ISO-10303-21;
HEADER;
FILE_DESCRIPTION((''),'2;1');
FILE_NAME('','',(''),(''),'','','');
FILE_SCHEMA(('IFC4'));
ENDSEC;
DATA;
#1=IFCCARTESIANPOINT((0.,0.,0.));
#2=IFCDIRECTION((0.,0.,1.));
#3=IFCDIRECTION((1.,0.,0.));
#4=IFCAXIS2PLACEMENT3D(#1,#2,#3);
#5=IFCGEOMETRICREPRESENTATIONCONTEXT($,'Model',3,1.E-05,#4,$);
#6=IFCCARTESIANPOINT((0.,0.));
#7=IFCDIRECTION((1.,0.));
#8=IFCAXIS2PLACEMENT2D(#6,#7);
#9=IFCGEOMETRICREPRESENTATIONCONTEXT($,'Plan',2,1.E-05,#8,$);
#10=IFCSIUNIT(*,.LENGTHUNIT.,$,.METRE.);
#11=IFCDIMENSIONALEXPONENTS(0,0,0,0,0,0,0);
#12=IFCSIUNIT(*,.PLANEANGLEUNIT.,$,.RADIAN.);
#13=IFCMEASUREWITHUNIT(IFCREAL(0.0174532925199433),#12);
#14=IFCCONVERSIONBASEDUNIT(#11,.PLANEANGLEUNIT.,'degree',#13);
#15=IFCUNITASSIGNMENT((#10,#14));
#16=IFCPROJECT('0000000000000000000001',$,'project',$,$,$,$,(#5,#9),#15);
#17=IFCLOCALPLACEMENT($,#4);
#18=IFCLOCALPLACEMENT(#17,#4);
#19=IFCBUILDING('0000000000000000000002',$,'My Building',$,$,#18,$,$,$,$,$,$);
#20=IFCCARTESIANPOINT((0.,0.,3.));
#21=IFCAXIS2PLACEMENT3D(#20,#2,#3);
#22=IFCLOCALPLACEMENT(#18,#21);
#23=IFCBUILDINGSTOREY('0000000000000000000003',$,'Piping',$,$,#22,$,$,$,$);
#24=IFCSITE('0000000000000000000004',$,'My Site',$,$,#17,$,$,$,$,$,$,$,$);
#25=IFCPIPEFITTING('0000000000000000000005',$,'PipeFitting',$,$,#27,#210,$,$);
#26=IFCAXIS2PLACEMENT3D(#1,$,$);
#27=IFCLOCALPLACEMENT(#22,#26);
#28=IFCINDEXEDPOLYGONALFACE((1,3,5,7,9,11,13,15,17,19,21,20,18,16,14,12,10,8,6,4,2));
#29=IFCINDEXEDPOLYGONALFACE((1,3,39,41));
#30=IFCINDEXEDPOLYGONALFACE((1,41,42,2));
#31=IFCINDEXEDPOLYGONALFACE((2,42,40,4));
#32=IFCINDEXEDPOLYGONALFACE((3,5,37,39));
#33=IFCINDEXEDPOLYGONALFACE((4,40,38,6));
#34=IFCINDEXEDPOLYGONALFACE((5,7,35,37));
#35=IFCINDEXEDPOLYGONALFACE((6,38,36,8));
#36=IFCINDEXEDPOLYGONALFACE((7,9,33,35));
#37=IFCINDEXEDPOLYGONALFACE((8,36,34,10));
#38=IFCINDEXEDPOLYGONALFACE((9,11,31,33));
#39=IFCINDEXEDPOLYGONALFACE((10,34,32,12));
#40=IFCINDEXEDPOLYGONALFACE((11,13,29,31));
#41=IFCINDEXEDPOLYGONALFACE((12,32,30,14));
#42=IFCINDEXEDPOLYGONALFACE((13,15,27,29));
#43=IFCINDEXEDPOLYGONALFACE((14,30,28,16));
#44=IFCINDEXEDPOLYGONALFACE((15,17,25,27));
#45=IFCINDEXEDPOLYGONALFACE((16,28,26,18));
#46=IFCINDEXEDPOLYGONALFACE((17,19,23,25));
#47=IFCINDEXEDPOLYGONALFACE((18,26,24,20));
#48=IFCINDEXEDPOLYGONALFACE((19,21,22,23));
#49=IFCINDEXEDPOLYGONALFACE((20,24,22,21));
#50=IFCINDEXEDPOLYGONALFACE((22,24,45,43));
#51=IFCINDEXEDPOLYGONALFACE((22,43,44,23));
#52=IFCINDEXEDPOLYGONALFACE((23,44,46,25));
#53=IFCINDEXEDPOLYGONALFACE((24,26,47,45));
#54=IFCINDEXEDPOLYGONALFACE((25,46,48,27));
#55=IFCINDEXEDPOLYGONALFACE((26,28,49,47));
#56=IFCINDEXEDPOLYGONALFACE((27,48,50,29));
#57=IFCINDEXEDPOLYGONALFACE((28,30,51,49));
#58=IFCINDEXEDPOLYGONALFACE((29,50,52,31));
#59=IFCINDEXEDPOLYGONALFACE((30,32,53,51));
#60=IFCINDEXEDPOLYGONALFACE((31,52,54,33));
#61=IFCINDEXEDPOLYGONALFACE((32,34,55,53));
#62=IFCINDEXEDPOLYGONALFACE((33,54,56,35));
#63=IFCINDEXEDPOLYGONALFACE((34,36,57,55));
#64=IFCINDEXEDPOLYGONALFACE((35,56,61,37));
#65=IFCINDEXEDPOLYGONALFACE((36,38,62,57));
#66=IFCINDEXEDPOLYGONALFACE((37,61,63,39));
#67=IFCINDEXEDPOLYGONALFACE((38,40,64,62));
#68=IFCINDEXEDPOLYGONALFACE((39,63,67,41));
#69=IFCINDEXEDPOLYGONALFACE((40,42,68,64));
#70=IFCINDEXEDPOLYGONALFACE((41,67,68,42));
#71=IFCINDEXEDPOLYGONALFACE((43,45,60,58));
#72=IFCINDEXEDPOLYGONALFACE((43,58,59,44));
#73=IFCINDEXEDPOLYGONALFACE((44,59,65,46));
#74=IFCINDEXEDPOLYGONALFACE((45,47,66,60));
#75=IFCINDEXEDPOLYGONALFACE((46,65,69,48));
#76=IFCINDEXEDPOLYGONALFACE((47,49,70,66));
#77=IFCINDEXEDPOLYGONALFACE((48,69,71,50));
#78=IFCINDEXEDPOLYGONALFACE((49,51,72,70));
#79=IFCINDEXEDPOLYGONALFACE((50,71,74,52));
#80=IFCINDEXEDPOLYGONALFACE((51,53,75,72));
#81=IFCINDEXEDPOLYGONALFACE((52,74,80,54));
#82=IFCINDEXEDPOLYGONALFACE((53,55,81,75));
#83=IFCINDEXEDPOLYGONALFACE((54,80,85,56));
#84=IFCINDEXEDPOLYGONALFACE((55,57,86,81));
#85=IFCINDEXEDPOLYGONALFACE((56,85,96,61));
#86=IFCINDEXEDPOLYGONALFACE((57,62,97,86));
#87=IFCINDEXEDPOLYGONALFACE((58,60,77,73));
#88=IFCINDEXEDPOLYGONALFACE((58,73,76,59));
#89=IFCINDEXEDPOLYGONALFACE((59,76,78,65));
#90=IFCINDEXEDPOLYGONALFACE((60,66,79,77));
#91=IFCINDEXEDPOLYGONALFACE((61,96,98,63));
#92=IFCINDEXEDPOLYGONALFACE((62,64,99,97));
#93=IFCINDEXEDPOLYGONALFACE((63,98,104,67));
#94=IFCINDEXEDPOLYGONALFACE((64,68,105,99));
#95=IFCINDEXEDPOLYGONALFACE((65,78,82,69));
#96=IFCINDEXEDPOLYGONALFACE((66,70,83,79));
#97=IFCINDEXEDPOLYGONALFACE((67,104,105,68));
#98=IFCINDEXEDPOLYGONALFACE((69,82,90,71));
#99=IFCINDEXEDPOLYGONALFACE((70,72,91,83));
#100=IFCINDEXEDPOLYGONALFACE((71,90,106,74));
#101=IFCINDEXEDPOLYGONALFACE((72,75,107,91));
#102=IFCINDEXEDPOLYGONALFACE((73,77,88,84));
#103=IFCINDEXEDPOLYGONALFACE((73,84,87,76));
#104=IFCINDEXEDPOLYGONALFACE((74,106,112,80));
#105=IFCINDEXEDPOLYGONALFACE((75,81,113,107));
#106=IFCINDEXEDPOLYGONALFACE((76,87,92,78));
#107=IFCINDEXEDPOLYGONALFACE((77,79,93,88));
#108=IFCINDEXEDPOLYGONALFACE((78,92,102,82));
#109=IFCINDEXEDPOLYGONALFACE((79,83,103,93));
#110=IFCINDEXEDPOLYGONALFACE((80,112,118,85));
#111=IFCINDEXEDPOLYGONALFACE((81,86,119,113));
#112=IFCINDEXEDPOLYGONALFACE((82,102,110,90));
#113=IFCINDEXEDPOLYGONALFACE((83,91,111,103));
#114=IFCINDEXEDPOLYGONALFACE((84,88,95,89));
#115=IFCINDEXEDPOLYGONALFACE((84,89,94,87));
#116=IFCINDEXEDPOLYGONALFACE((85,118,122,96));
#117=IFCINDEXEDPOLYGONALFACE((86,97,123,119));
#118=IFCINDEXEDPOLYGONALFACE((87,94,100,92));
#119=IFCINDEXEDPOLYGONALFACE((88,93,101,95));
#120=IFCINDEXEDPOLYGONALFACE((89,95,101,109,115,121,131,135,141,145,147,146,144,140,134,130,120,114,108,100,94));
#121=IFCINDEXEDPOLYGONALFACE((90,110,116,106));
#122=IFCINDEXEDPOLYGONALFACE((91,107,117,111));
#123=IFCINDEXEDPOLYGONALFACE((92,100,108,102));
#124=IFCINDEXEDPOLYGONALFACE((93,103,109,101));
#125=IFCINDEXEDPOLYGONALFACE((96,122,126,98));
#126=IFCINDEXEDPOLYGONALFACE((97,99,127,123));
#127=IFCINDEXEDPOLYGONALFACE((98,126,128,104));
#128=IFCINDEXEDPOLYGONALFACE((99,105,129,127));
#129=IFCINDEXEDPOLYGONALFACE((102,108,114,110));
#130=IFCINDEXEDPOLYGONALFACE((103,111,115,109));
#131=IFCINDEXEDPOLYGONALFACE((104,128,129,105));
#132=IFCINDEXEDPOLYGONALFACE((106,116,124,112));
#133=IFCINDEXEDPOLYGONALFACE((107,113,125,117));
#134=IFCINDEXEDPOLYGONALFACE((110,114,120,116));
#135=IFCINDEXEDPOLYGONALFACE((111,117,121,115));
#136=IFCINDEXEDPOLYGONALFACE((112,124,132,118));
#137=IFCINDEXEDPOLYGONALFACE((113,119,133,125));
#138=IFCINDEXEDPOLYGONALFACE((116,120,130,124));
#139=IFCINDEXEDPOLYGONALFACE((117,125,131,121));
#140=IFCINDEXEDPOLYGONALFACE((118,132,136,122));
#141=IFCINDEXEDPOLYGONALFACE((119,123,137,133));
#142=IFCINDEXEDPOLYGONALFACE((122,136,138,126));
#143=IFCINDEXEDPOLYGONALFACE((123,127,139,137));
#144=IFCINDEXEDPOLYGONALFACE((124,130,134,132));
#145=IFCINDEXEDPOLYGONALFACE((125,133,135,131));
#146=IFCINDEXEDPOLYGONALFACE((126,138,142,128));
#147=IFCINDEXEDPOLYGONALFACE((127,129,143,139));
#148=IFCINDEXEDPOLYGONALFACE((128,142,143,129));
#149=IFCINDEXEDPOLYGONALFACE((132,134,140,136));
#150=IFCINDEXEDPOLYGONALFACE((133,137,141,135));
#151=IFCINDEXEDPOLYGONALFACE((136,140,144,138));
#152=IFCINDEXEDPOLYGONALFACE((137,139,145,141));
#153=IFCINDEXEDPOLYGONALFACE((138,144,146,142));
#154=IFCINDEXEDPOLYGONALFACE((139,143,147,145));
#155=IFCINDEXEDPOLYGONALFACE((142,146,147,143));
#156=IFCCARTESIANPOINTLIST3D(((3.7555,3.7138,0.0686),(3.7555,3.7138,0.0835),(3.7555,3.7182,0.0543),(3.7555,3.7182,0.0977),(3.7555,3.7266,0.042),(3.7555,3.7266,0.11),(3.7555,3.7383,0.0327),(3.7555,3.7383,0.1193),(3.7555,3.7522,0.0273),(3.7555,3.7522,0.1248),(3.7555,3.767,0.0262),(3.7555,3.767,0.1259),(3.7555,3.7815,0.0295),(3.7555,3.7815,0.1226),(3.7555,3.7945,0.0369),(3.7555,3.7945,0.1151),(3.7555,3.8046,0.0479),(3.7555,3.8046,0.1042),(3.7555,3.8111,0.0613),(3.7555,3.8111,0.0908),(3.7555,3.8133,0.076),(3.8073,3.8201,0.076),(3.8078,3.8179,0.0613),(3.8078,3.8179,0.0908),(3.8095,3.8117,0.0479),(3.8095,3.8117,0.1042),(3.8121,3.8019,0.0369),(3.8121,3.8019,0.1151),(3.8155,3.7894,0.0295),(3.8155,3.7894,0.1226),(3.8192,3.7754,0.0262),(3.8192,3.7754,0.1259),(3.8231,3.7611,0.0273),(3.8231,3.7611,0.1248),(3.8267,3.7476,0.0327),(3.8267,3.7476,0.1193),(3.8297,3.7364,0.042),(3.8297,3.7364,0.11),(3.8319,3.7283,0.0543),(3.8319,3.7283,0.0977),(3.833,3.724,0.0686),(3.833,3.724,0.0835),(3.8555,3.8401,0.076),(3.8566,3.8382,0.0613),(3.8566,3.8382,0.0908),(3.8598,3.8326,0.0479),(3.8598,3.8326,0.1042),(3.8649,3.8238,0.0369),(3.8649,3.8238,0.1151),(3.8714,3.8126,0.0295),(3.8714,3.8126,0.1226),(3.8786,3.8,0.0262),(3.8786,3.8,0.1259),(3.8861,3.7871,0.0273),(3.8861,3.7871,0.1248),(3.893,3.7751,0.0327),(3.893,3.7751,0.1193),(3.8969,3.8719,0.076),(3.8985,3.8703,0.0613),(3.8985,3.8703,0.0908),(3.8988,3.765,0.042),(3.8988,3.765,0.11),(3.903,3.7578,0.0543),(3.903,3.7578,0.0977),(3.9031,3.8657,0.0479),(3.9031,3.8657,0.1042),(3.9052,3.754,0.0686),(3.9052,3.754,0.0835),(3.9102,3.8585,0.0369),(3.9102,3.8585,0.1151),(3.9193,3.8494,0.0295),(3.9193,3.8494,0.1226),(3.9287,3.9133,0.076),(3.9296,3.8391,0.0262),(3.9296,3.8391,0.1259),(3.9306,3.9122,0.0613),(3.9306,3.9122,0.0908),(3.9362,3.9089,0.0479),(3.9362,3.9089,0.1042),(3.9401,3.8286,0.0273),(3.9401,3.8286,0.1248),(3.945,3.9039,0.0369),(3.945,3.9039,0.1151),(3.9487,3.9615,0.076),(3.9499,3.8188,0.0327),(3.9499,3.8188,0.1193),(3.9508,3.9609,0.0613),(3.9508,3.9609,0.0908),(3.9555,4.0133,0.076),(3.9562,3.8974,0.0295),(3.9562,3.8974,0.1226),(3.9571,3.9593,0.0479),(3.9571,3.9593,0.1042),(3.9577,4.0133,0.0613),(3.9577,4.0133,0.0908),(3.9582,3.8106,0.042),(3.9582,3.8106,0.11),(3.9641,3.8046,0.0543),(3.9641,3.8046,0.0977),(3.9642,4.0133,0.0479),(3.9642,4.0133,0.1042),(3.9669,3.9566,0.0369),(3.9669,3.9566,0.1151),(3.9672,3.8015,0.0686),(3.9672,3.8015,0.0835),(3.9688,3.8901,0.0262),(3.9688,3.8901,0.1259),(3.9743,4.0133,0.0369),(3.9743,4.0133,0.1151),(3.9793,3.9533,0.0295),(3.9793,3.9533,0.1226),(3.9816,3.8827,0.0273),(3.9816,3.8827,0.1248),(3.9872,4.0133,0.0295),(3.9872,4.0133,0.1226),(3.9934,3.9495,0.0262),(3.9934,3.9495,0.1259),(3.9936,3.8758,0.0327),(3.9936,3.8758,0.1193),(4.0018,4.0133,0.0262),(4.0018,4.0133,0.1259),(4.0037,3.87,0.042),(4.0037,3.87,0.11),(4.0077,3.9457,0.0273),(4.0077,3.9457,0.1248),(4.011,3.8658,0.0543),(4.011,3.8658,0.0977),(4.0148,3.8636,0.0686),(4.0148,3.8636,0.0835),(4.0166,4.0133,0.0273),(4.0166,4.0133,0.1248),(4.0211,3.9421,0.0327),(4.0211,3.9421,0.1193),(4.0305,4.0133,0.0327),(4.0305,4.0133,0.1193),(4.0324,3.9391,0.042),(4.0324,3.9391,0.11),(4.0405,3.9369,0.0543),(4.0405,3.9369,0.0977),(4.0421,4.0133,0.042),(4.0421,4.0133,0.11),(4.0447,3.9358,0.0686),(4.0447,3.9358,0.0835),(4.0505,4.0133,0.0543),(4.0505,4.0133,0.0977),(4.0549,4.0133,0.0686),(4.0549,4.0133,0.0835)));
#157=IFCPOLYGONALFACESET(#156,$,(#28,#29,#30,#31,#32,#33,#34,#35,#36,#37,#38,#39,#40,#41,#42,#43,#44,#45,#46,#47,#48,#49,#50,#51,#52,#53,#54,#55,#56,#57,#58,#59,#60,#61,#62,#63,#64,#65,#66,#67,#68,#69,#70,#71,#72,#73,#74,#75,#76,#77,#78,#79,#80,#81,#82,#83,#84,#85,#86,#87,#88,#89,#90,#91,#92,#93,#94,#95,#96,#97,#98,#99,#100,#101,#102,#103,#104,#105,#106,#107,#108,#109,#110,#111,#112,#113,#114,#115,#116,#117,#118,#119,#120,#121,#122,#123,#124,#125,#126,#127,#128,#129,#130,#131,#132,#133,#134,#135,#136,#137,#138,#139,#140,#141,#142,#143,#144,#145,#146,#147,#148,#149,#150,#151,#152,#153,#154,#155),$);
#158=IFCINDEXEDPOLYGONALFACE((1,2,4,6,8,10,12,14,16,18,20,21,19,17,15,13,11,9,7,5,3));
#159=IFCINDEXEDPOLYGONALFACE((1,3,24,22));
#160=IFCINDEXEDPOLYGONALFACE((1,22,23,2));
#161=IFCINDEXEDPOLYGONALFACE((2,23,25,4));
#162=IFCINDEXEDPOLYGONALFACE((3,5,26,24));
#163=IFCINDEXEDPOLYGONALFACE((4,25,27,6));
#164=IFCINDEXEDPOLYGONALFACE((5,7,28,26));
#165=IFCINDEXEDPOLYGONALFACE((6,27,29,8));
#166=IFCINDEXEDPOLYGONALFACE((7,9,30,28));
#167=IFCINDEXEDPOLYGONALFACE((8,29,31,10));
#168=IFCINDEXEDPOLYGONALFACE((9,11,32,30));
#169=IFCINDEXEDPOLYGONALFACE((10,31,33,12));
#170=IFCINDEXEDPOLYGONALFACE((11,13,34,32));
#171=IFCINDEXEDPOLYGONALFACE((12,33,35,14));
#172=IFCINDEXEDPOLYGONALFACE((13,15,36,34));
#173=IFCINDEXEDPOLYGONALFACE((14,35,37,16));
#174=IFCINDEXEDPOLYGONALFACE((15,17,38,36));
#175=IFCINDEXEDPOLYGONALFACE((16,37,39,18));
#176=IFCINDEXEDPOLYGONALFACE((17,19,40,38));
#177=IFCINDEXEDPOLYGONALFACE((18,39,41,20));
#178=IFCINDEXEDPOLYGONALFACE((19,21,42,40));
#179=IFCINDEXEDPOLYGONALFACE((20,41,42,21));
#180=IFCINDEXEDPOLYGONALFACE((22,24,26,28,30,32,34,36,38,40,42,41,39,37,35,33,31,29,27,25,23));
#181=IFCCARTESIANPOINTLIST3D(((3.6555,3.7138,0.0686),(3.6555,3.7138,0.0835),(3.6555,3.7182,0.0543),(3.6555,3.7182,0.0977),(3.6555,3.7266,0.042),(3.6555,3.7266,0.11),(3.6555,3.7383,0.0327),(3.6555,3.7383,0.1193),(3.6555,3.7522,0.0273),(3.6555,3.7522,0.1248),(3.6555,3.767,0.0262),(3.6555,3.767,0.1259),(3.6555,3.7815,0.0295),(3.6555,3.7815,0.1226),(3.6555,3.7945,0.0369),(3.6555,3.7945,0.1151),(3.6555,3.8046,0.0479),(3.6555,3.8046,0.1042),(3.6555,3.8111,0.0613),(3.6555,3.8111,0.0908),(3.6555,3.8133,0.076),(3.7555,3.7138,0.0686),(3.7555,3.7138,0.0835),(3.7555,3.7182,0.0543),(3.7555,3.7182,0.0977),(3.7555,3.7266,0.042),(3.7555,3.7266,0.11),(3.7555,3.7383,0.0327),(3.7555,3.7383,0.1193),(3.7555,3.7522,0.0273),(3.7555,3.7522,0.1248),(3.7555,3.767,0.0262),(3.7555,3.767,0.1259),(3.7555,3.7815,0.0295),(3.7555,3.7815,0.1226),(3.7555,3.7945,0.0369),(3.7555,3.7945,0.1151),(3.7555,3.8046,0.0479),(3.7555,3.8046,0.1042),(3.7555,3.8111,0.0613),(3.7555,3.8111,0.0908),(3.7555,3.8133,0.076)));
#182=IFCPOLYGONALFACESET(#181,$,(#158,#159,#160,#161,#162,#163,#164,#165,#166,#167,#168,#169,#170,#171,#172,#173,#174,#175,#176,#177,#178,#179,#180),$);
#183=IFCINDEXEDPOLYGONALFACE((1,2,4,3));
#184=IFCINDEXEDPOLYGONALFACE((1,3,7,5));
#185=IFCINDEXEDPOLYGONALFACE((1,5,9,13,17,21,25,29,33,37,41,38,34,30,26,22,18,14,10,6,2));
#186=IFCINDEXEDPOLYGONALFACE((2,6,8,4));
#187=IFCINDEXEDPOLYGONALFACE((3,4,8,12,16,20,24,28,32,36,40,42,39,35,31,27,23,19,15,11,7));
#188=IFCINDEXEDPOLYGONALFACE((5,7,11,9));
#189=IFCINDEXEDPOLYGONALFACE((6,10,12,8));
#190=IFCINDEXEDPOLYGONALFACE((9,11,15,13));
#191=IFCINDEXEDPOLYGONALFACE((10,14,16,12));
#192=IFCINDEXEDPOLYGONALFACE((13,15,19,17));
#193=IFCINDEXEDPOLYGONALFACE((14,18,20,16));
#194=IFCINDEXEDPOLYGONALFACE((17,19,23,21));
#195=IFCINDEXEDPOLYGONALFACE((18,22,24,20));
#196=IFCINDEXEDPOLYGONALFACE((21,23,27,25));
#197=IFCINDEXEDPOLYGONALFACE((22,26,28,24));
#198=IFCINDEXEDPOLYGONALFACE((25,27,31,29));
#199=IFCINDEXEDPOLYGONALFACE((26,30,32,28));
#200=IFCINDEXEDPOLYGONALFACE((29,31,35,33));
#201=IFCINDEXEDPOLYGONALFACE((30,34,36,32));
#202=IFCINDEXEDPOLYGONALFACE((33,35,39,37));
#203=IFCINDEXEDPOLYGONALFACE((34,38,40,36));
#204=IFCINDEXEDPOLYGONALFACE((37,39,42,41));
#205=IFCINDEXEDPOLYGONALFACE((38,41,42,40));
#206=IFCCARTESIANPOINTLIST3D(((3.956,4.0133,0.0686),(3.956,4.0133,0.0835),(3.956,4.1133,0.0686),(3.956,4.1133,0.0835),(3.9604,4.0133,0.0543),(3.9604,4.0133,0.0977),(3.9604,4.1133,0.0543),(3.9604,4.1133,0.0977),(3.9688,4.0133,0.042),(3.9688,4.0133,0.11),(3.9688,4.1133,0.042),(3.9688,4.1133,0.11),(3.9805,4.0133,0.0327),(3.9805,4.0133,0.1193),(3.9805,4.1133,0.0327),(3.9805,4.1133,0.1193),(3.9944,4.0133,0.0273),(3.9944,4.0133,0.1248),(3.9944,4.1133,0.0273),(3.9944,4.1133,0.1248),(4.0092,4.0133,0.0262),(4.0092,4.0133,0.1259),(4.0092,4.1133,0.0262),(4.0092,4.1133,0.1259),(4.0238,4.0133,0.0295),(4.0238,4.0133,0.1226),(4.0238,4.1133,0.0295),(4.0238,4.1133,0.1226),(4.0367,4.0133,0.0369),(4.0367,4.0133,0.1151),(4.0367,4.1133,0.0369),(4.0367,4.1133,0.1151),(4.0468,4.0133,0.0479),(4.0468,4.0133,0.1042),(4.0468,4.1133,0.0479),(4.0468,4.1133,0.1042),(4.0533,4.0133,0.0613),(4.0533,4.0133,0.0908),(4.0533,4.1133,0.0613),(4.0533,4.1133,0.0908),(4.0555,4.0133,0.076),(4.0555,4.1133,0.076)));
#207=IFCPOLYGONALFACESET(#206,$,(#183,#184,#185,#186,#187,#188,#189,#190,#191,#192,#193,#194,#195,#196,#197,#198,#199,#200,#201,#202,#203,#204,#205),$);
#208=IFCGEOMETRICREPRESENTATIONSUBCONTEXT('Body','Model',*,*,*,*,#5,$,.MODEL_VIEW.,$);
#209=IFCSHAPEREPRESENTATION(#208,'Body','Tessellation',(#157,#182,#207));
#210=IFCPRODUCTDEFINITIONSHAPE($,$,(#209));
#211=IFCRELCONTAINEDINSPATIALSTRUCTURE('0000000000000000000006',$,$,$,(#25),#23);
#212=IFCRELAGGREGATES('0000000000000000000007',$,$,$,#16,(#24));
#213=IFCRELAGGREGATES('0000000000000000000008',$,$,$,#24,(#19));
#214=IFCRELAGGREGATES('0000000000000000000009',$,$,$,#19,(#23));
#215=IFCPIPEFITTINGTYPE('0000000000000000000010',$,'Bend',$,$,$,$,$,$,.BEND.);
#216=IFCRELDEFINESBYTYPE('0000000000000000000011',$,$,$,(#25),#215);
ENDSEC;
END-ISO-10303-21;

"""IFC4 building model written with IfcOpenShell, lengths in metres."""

from ifc_helpers import new_model, entity, si_unit, converted_unit, frame, origin_with_axes, origin_2d_with_axis, place, context, subcontext, project, spatial, circle, extrude, source, transform, mapped, type_object, type_shapes, element, save


model = new_model("IFC4")

# Units and contexts
model_context = context("Model", 3, precision=1e-05, world=origin_with_axes())
plan_context = context("Plan", 2, precision=1e-05, world=origin_2d_with_axis())
body_context = subcontext(model_context, "Body", "Model", "MODEL_VIEW")
ifc_project = project(units=[si_unit("LENGTHUNIT", "METRE"), converted_unit("PLANEANGLEUNIT", "degree", entity("IfcReal", 0.0174532925199433), si_unit("PLANEANGLEUNIT", "RADIAN"), dimensions=[0, 0, 0, 0, 0, 0, 0])], contexts=[model_context, plan_context])

# Site, building, storey
site_placement = place(None, origin_with_axes())
site = spatial("IfcSite", under=ifc_project, at=site_placement, Name="My Site")
building_placement = place(site_placement, origin_with_axes())
building = spatial("IfcBuilding", under=site, at=building_placement, Name="My Building")
storey_placement = place(building_placement, frame((0.0, 0.0, 3.0), z_axis=(0.0, 0.0, 1.0), x_axis=(1.0, 0.0, 0.0)))
storey = spatial("IfcBuildingStorey", under=building, at=storey_placement, Name="Piping")

# Pipe fitting
pipe_fitting_type_1 = type_object("IfcPipeFittingType", Name="Bend", PredefinedType="BEND")
shared_shape_1 = source(origin_with_axes(), body_context, "Body", "SolidModel", [
    entity("IfcSweptDiskSolid", entity("IfcIndexedPolyCurve", entity("IfcCartesianPointList3D", [[0.0, 0.0, 0.1], [0.0732, 0.0, 0.2768], [0.25, 0.0, 0.35]]), [entity("IfcArcIndex", [1, 2, 3])]), 0.05),
    extrude(circle(Radius=0.05), origin_with_axes(), (0.0, 0.0, 1.0), 0.1),
    extrude(circle(Radius=0.05), frame((0.25, 0.0, 0.35), z_axis=(1.0, 0.0, 0.0), x_axis=(0.0, 0.0, 1.0)), (0.0, 0.0, 1.0), 0.1),
])
type_shapes(pipe_fitting_type_1, [shared_shape_1])
for number, where, z_axis, x_axis, name in (
    (1, (3.6555, 3.7633, 0.076), (1.0, 0.0, 0.0), (0.0, 1.0, 0.0), "PipeFitting"),
):
    element("IfcPipeFitting", number, at=place(storey_placement, frame(where, z_axis=z_axis, x_axis=x_axis)), inside=storey, type_object=pipe_fitting_type_1, Name=name, context=body_context, shape_type="MappedRepresentation", body=[
        mapped(shared_shape_1, transform((0.0, 0.0, 0.0), x_axis=(1.0, 0.0, 0.0), y_axis=(0.0, 1.0, 0.0), z_axis=(0.0, 0.0, 1.0), scale=1.0)),
    ])

save(model, "model.ifc")
